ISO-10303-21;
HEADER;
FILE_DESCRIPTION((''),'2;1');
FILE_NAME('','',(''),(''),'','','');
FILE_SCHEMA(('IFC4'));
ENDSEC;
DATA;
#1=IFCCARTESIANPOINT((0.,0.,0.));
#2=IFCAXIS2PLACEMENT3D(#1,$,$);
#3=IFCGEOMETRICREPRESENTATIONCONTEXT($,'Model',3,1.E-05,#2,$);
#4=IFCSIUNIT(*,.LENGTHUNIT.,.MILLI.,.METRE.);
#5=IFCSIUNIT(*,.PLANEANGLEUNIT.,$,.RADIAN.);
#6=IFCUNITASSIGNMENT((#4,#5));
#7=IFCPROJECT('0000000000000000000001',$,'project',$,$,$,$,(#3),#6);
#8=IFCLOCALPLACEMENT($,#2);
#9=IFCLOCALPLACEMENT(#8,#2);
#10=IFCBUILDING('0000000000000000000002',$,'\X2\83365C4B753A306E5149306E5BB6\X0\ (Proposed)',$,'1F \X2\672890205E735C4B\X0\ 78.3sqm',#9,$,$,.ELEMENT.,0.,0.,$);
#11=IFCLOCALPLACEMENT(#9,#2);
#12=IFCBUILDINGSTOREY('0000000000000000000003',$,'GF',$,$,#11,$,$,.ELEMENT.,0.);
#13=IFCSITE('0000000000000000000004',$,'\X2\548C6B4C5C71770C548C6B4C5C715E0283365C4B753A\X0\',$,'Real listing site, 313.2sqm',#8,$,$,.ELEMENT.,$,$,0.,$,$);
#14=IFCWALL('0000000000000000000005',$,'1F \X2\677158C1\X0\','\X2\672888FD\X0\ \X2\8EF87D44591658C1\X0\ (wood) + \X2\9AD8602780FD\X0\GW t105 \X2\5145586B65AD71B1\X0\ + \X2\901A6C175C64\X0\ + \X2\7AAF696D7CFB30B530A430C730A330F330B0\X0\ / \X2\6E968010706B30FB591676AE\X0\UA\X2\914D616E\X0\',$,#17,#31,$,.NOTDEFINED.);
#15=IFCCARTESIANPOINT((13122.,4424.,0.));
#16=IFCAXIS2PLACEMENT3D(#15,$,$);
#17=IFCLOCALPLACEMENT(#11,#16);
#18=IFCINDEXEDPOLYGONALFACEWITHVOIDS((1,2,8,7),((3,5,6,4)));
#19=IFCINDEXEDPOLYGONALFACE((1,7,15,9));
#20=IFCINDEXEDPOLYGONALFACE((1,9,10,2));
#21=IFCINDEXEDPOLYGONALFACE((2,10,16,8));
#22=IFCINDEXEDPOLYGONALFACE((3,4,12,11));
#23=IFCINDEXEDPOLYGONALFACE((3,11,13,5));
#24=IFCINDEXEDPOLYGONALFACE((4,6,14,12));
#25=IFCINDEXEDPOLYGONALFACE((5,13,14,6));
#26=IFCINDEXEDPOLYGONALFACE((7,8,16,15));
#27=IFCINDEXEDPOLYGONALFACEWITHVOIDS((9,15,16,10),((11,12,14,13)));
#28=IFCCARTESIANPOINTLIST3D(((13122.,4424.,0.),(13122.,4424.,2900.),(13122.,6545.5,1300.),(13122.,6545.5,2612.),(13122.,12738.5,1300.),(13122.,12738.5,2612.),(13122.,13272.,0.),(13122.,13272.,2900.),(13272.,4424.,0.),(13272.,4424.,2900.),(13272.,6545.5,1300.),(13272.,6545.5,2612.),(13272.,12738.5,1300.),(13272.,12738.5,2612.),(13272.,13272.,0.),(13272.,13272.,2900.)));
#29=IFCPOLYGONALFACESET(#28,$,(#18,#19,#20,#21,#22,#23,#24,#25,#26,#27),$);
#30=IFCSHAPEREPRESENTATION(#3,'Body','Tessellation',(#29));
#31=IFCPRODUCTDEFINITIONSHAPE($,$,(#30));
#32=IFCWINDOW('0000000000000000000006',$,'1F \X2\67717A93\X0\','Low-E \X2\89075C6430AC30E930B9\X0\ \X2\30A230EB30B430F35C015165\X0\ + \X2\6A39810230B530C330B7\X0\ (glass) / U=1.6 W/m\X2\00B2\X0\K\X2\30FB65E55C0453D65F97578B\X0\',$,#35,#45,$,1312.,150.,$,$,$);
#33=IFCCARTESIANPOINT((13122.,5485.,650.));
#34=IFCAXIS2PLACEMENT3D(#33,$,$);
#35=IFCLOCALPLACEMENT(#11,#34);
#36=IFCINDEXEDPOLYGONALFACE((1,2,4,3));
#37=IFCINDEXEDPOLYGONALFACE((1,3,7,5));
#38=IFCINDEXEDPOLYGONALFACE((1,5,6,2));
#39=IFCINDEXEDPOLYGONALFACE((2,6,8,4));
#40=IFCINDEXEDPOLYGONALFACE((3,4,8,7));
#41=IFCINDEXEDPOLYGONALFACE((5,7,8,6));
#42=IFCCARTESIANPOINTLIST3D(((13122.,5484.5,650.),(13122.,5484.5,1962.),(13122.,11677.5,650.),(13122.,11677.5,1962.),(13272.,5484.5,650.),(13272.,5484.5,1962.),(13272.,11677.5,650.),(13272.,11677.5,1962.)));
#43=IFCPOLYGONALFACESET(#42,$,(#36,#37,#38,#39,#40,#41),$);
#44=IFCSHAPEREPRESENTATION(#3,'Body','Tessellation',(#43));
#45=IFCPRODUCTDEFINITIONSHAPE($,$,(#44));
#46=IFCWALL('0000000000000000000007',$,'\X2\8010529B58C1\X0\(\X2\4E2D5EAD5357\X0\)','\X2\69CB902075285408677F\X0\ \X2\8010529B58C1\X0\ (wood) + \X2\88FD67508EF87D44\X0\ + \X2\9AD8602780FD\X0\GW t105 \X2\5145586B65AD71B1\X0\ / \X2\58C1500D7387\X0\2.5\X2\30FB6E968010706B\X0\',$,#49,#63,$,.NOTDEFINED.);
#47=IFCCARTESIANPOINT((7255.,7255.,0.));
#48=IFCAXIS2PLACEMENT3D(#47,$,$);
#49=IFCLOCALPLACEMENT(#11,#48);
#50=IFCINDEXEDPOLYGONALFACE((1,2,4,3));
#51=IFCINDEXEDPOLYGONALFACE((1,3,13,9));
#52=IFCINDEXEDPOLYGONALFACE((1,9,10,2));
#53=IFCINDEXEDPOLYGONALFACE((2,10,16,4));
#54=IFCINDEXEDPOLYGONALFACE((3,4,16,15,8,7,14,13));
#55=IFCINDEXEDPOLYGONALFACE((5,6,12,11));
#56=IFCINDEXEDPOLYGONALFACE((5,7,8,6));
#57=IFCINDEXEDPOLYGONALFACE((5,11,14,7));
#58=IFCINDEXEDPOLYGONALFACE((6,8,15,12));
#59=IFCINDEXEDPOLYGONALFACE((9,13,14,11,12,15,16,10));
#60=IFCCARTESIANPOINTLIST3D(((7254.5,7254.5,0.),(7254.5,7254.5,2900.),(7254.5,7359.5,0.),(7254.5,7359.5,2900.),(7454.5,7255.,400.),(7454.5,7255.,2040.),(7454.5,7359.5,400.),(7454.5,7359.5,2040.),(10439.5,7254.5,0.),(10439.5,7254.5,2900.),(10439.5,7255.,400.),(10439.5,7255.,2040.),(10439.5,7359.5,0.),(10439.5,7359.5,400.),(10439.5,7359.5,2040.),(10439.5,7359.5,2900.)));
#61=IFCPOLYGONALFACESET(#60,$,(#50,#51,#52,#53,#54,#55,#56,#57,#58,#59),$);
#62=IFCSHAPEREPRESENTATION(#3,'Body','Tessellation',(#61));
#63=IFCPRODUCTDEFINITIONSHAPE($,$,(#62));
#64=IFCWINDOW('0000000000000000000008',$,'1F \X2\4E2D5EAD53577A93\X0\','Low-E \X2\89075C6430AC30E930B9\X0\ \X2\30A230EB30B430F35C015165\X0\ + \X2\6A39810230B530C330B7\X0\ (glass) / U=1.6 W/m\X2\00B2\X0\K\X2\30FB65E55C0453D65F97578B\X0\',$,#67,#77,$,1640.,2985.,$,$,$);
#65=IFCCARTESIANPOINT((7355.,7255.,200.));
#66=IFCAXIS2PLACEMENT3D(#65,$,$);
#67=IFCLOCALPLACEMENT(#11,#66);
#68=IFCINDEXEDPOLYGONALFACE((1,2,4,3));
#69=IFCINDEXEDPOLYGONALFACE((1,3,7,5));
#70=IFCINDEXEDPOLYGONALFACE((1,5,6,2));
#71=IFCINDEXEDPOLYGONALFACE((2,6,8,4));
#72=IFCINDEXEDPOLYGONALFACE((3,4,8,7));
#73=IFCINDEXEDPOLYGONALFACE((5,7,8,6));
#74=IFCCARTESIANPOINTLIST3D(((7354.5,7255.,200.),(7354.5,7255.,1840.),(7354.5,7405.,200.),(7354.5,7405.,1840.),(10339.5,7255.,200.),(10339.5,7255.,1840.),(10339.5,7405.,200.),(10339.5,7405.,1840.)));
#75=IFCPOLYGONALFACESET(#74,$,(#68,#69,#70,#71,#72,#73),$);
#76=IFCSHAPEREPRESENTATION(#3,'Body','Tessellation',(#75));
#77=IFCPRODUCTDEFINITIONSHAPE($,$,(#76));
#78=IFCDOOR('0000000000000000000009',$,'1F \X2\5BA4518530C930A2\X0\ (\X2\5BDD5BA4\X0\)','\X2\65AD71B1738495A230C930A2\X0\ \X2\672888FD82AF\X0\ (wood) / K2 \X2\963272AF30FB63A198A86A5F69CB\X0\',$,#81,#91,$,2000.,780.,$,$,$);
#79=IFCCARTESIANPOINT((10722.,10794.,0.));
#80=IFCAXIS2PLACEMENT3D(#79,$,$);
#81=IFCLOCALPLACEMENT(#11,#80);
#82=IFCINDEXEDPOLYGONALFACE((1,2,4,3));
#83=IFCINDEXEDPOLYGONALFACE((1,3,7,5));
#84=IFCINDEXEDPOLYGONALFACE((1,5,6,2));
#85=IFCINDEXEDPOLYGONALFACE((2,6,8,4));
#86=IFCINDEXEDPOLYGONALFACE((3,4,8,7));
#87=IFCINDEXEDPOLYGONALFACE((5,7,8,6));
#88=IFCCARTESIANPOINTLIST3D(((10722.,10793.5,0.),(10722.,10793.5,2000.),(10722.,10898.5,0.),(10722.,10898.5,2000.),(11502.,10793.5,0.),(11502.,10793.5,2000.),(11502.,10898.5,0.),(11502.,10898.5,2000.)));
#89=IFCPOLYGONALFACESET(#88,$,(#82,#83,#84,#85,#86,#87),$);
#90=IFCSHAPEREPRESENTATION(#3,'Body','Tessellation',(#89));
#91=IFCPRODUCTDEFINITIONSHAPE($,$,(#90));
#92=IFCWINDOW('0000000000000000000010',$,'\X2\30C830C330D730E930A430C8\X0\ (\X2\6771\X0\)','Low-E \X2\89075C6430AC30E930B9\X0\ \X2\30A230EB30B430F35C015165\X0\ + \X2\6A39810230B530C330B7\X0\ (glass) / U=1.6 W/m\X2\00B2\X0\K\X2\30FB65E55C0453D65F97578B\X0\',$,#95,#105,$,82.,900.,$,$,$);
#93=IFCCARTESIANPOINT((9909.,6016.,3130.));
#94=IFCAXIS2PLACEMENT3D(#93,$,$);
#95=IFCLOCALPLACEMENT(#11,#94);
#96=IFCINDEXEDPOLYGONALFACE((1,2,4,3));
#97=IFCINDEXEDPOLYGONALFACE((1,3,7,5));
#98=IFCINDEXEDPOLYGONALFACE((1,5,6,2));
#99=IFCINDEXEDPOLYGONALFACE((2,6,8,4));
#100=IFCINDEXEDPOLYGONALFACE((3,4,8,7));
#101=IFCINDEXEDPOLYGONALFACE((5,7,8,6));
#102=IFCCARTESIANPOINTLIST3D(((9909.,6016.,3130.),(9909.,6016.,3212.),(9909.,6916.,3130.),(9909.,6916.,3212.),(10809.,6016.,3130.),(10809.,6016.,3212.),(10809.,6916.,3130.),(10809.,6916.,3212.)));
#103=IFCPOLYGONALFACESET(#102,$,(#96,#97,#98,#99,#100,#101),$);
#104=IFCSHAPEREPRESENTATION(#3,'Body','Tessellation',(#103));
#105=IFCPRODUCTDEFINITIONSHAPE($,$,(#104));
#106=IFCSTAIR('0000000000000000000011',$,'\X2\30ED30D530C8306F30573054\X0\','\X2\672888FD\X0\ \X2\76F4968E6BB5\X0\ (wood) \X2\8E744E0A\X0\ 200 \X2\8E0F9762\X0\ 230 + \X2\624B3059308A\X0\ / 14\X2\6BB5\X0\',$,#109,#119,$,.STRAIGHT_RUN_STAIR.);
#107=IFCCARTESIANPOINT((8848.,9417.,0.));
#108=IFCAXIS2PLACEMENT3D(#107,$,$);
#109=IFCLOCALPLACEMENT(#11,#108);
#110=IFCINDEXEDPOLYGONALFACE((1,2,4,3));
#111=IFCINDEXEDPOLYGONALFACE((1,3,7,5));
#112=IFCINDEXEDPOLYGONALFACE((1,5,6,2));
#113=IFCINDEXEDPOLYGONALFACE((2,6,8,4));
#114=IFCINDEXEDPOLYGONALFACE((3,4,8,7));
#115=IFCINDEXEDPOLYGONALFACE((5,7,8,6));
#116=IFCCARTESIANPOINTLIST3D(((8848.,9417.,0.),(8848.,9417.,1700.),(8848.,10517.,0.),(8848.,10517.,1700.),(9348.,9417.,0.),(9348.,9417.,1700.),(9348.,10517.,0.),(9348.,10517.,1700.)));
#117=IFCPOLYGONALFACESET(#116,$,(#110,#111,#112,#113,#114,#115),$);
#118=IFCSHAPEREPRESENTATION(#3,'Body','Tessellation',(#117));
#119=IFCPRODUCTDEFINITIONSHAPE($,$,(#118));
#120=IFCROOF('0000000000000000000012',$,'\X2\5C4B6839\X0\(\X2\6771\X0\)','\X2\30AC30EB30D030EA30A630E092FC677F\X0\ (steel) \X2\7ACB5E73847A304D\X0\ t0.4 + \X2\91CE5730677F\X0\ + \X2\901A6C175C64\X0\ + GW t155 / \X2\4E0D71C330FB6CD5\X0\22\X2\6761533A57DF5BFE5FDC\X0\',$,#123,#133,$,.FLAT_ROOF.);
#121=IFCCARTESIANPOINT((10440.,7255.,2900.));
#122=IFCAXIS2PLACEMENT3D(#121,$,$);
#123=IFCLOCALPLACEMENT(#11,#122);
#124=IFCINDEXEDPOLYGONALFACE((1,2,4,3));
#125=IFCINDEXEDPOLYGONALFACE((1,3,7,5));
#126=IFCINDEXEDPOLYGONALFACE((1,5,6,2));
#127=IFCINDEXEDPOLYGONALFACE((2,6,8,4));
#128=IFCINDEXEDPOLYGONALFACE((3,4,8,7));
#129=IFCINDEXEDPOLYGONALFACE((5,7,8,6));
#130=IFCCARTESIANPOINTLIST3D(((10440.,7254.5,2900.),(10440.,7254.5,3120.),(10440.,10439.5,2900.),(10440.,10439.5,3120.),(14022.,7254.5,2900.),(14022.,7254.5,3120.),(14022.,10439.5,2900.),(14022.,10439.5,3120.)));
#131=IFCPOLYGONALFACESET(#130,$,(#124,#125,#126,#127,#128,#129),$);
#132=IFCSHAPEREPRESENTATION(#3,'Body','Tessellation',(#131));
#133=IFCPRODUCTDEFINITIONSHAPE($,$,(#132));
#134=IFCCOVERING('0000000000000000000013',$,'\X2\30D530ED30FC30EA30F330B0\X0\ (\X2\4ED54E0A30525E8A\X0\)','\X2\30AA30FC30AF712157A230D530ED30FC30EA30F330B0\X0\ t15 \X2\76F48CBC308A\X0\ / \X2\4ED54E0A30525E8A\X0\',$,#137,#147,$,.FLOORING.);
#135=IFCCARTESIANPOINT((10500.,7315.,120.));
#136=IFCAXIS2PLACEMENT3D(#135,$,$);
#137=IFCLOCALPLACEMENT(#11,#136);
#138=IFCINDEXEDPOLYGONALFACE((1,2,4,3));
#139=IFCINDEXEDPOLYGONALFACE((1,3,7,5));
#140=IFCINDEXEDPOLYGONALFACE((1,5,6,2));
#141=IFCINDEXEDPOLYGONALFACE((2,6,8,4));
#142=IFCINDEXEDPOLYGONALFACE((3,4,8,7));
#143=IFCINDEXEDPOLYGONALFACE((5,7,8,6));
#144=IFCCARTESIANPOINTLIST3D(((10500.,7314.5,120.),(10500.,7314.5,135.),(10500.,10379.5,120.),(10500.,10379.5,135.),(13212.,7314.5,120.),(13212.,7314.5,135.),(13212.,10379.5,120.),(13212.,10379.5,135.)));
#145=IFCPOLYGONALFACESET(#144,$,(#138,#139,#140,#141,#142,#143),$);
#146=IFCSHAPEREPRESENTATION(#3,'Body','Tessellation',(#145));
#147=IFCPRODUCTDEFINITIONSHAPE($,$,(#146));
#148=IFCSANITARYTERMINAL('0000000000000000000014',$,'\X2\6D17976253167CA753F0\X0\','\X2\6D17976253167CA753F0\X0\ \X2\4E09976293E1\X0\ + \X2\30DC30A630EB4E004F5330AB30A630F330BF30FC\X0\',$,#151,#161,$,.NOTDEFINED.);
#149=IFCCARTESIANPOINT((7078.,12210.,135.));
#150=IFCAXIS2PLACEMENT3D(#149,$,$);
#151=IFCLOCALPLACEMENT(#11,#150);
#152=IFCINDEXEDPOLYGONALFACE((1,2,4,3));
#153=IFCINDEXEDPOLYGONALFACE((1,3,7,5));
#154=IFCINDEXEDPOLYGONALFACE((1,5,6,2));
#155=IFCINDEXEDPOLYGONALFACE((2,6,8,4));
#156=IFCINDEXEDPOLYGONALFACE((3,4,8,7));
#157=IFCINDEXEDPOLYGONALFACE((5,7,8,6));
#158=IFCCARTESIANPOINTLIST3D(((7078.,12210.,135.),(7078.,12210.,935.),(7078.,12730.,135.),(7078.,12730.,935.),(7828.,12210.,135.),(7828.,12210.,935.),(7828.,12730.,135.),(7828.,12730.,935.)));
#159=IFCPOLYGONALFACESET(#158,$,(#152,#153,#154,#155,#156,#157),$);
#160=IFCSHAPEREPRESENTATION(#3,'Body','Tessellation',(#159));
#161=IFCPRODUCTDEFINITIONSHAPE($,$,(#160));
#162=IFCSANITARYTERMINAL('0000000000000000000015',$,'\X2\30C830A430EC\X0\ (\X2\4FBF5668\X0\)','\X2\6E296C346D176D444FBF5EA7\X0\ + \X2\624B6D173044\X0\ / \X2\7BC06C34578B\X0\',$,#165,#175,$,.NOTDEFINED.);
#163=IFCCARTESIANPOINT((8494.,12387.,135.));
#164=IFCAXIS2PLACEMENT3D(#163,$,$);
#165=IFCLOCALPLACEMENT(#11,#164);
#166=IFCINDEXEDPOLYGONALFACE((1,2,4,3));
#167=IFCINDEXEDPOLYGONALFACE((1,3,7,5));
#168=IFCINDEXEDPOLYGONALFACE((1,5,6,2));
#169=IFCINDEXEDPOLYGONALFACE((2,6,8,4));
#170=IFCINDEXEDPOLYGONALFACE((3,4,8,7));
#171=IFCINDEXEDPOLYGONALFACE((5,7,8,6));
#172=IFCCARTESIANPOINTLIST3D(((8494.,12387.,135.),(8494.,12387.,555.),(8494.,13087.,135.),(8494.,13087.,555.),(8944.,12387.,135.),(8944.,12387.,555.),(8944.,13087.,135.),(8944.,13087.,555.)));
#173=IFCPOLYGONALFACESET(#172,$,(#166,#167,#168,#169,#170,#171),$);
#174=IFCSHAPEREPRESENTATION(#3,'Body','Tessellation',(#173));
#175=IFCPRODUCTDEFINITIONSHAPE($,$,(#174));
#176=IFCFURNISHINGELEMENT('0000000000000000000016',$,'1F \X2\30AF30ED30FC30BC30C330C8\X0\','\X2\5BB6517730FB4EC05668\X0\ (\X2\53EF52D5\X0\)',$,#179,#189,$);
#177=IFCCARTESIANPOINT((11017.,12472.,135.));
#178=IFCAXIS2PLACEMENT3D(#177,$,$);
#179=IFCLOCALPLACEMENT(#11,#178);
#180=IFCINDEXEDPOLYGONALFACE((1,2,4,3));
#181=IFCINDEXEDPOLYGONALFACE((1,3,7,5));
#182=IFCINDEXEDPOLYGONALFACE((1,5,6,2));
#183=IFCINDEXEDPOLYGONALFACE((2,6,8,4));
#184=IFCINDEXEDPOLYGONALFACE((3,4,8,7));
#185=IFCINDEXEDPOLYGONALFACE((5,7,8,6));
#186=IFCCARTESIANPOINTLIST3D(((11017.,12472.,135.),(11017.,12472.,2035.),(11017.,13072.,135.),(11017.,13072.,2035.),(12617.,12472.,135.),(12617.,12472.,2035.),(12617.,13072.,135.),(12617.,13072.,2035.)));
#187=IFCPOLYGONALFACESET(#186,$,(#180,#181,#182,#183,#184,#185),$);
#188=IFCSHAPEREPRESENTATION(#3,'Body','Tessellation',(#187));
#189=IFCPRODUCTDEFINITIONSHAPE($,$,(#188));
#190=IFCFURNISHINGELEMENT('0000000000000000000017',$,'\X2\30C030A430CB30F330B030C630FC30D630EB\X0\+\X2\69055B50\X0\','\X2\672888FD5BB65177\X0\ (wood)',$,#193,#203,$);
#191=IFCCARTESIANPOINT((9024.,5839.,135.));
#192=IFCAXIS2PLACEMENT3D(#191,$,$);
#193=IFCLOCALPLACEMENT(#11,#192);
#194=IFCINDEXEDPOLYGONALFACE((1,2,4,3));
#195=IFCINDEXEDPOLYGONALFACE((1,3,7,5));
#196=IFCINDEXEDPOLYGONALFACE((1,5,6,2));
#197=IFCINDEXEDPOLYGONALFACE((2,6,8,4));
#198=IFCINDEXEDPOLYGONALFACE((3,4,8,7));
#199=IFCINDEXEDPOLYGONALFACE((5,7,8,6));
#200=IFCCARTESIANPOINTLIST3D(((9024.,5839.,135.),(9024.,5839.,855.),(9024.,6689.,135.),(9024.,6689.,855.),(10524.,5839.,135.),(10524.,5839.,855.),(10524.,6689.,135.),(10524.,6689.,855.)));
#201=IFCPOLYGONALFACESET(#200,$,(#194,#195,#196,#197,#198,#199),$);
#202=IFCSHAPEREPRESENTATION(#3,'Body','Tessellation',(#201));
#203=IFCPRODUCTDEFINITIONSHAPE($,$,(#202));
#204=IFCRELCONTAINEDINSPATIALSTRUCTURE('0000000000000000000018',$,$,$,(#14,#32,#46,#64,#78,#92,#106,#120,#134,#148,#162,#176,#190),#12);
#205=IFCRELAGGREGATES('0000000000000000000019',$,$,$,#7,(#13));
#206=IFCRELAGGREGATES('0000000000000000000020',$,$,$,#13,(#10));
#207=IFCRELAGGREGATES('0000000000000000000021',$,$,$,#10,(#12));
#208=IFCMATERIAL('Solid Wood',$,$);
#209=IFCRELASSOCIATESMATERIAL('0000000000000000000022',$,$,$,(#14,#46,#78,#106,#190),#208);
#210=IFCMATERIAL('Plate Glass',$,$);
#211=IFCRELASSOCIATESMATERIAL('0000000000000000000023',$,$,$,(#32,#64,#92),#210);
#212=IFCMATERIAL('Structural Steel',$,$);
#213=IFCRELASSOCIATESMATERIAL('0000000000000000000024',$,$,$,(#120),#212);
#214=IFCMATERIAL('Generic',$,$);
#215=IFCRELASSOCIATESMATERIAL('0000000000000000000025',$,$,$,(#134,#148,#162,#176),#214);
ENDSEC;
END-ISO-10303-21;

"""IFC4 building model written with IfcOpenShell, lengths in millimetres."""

from ifc_helpers import new_model, si_unit, frame, frame_2d, origin, place, context, project, spatial, rectangle, extrude, material, element, fill, save


model = new_model("IFC4")

# Units and contexts
model_context = context("Model", 3, precision=1e-05, world=origin())
ifc_project = project(units=[si_unit("LENGTHUNIT", "METRE", prefix="MILLI"), si_unit("PLANEANGLEUNIT", "RADIAN")], contexts=[model_context])

# Site, building, storey
site_placement = place(None, origin())
site = spatial("IfcSite", under=ifc_project, at=site_placement, Name="和歌山県和歌山市茶屋町", ObjectType="Real listing site, 313.2sqm", CompositionType="ELEMENT", RefElevation=0.0)
building_placement = place(site_placement, origin())
building = spatial("IfcBuilding", under=site, at=building_placement, Name="茶屋町の光の家 (Proposed)", ObjectType="1F 木造平屋 78.3sqm", CompositionType="ELEMENT", ElevationOfRefHeight=0.0, ElevationOfTerrain=0.0)
storey_placement = place(building_placement, origin())
storey = spatial("IfcBuildingStorey", under=building, at=storey_placement, Name="GF", CompositionType="ELEMENT", Elevation=0.0)

# Shared definitions
ifc_material_1 = material(Name="Solid Wood")

# Walls, openings, windows
wall_1_placement = place(storey_placement, frame((13122.0, 4424.0, 0.0)))
wall_1 = element("IfcWall", 1, at=wall_1_placement, inside=storey, material=ifc_material_1, Name="1F 東壁", Description="木製 軸組外壁 (wood) + 高性能GW t105 充填断熱 + 通気層 + 窯業系サイディング / 準耐火・外皮UA配慮", PredefinedType="NOTDEFINED", context=model_context, shape_type="SweptSolid", body=[
    extrude(rectangle(XDim=150.0, YDim=8848.0, at=frame_2d((75.0, 4424.0))), frame((13122.0, 4424.0, 0.0)), (0.0, 0.0, 1.0), 2900.0),
])
opening_1_placement = place(storey_placement, frame((13122.0, 5485.0, 650.0)))
opening_1 = element("IfcOpeningElement", 2, at=opening_1_placement, cuts=wall_1, PredefinedType="NOTDEFINED", context=model_context, shape_type="SweptSolid", body=[
    extrude(rectangle(XDim=150.0, YDim=6193.0, at=frame_2d((75.0, 3096.0))), frame((13122.0, 5485.0, 650.0)), (0.0, 0.0, 1.0), 1312.0),
])
ifc_material_2 = material(Name="Plate Glass")
window_1_placement = place(storey_placement, frame((13122.0, 5485.0, 650.0)))
window_1 = element("IfcWindow", 3, at=window_1_placement, inside=storey, material=ifc_material_2, Name="1F 東窓", Description="Low-E 複層ガラス アルゴン封入 + 樹脂サッシ (glass) / U=1.6 W/m²K・日射取得型", OverallHeight=1312.0, OverallWidth=150.0, context=model_context, shape_type="SweptSolid", body=[
    extrude(rectangle(XDim=150.0, YDim=6193.0, at=frame_2d((75.0, 3096.0))), frame((13122.0, 5485.0, 650.0)), (0.0, 0.0, 1.0), 1312.0),
])
fill(opening_1, window_1)
wall_2_placement = place(storey_placement, frame((7255.0, 7255.0, 0.0)))
wall_2 = element("IfcWall", 4, at=wall_2_placement, inside=storey, material=ifc_material_1, Name="耐力壁(中庭南)", Description="構造用合板 耐力壁 (wood) + 製材軸組 + 高性能GW t105 充填断熱 / 壁倍率2.5・準耐火", PredefinedType="NOTDEFINED", context=model_context, shape_type="SweptSolid", body=[
    extrude(rectangle(XDim=3185.0, YDim=105.0, at=frame_2d((1592.0, 52.0))), frame((7255.0, 7255.0, 0.0)), (0.0, 0.0, 1.0), 2900.0),
])
opening_2_placement = place(storey_placement, frame((7355.0, 7255.0, 200.0)))
opening_2 = element("IfcOpeningElement", 5, at=opening_2_placement, cuts=wall_2, PredefinedType="NOTDEFINED", context=model_context, shape_type="SweptSolid", body=[
    extrude(rectangle(XDim=2985.0, YDim=150.0, at=frame_2d((1492.0, 75.0))), frame((7355.0, 7255.0, 200.0)), (0.0, 0.0, 1.0), 1640.0),
])
window_2_placement = place(storey_placement, frame((7355.0, 7255.0, 200.0)))
window_2 = element("IfcWindow", 6, at=window_2_placement, inside=storey, material=ifc_material_2, Name="1F 中庭南窓", Description="Low-E 複層ガラス アルゴン封入 + 樹脂サッシ (glass) / U=1.6 W/m²K・日射取得型", OverallHeight=1640.0, OverallWidth=2985.0, context=model_context, shape_type="SweptSolid", body=[
    extrude(rectangle(XDim=2985.0, YDim=150.0, at=frame_2d((1492.0, 75.0))), frame((7355.0, 7255.0, 200.0)), (0.0, 0.0, 1.0), 1640.0),
])
fill(opening_2, window_2)

# Door
door_placement = place(storey_placement, frame((10722.0, 10794.0, 0.0)))
element("IfcDoor", 7, at=door_placement, inside=storey, material=ifc_material_1, Name="1F 室内ドア (寝室)", Description="断熱玄関ドア 木製芯 (wood) / K2 防犯・採風機構", OverallHeight=2000.0, OverallWidth=780.0, context=model_context, shape_type="SweptSolid", body=[
    extrude(rectangle(XDim=780.0, YDim=105.0, at=frame_2d((390.0, 52.0))), frame((10722.0, 10794.0, 0.0)), (0.0, 0.0, 1.0), 2000.0),
])

# Window
window_3_placement = place(storey_placement, frame((9909.0, 6016.0, 3130.0)))
element("IfcWindow", 8, at=window_3_placement, inside=storey, material=ifc_material_2, Name="トップライト (東)", Description="Low-E 複層ガラス アルゴン封入 + 樹脂サッシ (glass) / U=1.6 W/m²K・日射取得型", OverallHeight=82.0, OverallWidth=900.0, context=model_context, shape_type="SweptSolid", body=[
    extrude(rectangle(XDim=900.0, YDim=900.0, at=frame_2d((450.0, 450.0))), frame((9909.0, 6016.0, 3130.0)), (0.0, 0.0, 1.0), 82.0),
])

# Stair
stair_placement = place(storey_placement, frame((8848.0, 9417.0, 0.0)))
element("IfcStair", 9, at=stair_placement, inside=storey, material=ifc_material_1, Name="ロフトはしご", Description="木製 直階段 (wood) 蹴上 200 踏面 230 + 手すり / 14段", PredefinedType="STRAIGHT_RUN_STAIR", context=model_context, shape_type="SweptSolid", body=[
    extrude(rectangle(XDim=500.0, YDim=1100.0, at=frame_2d((250.0, 550.0))), frame((8848.0, 9417.0, 0.0)), (0.0, 0.0, 1.0), 1700.0),
])

# Roof
ifc_material_3 = material(Name="Structural Steel")
roof_placement = place(storey_placement, frame((10440.0, 7255.0, 2900.0)))
element("IfcRoof", 10, at=roof_placement, inside=storey, material=ifc_material_3, Name="屋根(東)", Description="ガルバリウム鋼板 (steel) 立平葺き t0.4 + 野地板 + 通気層 + GW t155 / 不燃・法22条区域対応", PredefinedType="FLAT_ROOF", context=model_context, shape_type="SweptSolid", body=[
    extrude(rectangle(XDim=3582.0, YDim=3185.0, at=frame_2d((1791.0, 1592.0))), frame((10440.0, 7255.0, 2900.0)), (0.0, 0.0, 1.0), 220.0),
])

# Covering
ifc_material_4 = material(Name="Generic")
covering_placement = place(storey_placement, frame((10500.0, 7315.0, 120.0)))
element("IfcCovering", 11, at=covering_placement, inside=storey, material=ifc_material_4, Name="フローリング (仕上げ床)", Description="オーク無垢フローリング t15 直貼り / 仕上げ床", PredefinedType="FLOORING", context=model_context, shape_type="SweptSolid", body=[
    extrude(rectangle(XDim=2712.0, YDim=3065.0, at=frame_2d((1356.0, 1532.0))), frame((10500.0, 7315.0, 120.0)), (0.0, 0.0, 1.0), 15.0),
])

# Sanitary terminals
sanitary_terminal_1_placement = place(storey_placement, frame((7078.0, 12210.0, 135.0)))
element("IfcSanitaryTerminal", 12, at=sanitary_terminal_1_placement, inside=storey, material=ifc_material_4, Name="洗面化粧台", Description="洗面化粧台 三面鏡 + ボウル一体カウンター", PredefinedType="NOTDEFINED", context=model_context, shape_type="SweptSolid", body=[
    extrude(rectangle(XDim=750.0, YDim=520.0, at=frame_2d((375.0, 260.0))), frame((7078.0, 12210.0, 135.0)), (0.0, 0.0, 1.0), 800.0),
])
sanitary_terminal_2_placement = place(storey_placement, frame((8494.0, 12387.0, 135.0)))
element("IfcSanitaryTerminal", 13, at=sanitary_terminal_2_placement, inside=storey, material=ifc_material_4, Name="トイレ (便器)", Description="温水洗浄便座 + 手洗い / 節水型", PredefinedType="NOTDEFINED", context=model_context, shape_type="SweptSolid", body=[
    extrude(rectangle(XDim=450.0, YDim=700.0, at=frame_2d((225.0, 350.0))), frame((8494.0, 12387.0, 135.0)), (0.0, 0.0, 1.0), 420.0),
])

# Furnishing elements
furnishing_1_placement = place(storey_placement, frame((11017.0, 12472.0, 135.0)))
element("IfcFurnishingElement", 14, at=furnishing_1_placement, inside=storey, material=ifc_material_4, Name="1F クローゼット", Description="家具・什器 (可動)", context=model_context, shape_type="SweptSolid", body=[
    extrude(rectangle(XDim=1600.0, YDim=600.0, at=frame_2d((800.0, 300.0))), frame((11017.0, 12472.0, 135.0)), (0.0, 0.0, 1.0), 1900.0),
])
furnishing_2_placement = place(storey_placement, frame((9024.0, 5839.0, 135.0)))
element("IfcFurnishingElement", 15, at=furnishing_2_placement, inside=storey, material=ifc_material_1, Name="ダイニングテーブル+椅子", Description="木製家具 (wood)", context=model_context, shape_type="SweptSolid", body=[
    extrude(rectangle(XDim=1500.0, YDim=850.0, at=frame_2d((750.0, 425.0))), frame((9024.0, 5839.0, 135.0)), (0.0, 0.0, 1.0), 720.0),
])

save(model, "model.ifc")
